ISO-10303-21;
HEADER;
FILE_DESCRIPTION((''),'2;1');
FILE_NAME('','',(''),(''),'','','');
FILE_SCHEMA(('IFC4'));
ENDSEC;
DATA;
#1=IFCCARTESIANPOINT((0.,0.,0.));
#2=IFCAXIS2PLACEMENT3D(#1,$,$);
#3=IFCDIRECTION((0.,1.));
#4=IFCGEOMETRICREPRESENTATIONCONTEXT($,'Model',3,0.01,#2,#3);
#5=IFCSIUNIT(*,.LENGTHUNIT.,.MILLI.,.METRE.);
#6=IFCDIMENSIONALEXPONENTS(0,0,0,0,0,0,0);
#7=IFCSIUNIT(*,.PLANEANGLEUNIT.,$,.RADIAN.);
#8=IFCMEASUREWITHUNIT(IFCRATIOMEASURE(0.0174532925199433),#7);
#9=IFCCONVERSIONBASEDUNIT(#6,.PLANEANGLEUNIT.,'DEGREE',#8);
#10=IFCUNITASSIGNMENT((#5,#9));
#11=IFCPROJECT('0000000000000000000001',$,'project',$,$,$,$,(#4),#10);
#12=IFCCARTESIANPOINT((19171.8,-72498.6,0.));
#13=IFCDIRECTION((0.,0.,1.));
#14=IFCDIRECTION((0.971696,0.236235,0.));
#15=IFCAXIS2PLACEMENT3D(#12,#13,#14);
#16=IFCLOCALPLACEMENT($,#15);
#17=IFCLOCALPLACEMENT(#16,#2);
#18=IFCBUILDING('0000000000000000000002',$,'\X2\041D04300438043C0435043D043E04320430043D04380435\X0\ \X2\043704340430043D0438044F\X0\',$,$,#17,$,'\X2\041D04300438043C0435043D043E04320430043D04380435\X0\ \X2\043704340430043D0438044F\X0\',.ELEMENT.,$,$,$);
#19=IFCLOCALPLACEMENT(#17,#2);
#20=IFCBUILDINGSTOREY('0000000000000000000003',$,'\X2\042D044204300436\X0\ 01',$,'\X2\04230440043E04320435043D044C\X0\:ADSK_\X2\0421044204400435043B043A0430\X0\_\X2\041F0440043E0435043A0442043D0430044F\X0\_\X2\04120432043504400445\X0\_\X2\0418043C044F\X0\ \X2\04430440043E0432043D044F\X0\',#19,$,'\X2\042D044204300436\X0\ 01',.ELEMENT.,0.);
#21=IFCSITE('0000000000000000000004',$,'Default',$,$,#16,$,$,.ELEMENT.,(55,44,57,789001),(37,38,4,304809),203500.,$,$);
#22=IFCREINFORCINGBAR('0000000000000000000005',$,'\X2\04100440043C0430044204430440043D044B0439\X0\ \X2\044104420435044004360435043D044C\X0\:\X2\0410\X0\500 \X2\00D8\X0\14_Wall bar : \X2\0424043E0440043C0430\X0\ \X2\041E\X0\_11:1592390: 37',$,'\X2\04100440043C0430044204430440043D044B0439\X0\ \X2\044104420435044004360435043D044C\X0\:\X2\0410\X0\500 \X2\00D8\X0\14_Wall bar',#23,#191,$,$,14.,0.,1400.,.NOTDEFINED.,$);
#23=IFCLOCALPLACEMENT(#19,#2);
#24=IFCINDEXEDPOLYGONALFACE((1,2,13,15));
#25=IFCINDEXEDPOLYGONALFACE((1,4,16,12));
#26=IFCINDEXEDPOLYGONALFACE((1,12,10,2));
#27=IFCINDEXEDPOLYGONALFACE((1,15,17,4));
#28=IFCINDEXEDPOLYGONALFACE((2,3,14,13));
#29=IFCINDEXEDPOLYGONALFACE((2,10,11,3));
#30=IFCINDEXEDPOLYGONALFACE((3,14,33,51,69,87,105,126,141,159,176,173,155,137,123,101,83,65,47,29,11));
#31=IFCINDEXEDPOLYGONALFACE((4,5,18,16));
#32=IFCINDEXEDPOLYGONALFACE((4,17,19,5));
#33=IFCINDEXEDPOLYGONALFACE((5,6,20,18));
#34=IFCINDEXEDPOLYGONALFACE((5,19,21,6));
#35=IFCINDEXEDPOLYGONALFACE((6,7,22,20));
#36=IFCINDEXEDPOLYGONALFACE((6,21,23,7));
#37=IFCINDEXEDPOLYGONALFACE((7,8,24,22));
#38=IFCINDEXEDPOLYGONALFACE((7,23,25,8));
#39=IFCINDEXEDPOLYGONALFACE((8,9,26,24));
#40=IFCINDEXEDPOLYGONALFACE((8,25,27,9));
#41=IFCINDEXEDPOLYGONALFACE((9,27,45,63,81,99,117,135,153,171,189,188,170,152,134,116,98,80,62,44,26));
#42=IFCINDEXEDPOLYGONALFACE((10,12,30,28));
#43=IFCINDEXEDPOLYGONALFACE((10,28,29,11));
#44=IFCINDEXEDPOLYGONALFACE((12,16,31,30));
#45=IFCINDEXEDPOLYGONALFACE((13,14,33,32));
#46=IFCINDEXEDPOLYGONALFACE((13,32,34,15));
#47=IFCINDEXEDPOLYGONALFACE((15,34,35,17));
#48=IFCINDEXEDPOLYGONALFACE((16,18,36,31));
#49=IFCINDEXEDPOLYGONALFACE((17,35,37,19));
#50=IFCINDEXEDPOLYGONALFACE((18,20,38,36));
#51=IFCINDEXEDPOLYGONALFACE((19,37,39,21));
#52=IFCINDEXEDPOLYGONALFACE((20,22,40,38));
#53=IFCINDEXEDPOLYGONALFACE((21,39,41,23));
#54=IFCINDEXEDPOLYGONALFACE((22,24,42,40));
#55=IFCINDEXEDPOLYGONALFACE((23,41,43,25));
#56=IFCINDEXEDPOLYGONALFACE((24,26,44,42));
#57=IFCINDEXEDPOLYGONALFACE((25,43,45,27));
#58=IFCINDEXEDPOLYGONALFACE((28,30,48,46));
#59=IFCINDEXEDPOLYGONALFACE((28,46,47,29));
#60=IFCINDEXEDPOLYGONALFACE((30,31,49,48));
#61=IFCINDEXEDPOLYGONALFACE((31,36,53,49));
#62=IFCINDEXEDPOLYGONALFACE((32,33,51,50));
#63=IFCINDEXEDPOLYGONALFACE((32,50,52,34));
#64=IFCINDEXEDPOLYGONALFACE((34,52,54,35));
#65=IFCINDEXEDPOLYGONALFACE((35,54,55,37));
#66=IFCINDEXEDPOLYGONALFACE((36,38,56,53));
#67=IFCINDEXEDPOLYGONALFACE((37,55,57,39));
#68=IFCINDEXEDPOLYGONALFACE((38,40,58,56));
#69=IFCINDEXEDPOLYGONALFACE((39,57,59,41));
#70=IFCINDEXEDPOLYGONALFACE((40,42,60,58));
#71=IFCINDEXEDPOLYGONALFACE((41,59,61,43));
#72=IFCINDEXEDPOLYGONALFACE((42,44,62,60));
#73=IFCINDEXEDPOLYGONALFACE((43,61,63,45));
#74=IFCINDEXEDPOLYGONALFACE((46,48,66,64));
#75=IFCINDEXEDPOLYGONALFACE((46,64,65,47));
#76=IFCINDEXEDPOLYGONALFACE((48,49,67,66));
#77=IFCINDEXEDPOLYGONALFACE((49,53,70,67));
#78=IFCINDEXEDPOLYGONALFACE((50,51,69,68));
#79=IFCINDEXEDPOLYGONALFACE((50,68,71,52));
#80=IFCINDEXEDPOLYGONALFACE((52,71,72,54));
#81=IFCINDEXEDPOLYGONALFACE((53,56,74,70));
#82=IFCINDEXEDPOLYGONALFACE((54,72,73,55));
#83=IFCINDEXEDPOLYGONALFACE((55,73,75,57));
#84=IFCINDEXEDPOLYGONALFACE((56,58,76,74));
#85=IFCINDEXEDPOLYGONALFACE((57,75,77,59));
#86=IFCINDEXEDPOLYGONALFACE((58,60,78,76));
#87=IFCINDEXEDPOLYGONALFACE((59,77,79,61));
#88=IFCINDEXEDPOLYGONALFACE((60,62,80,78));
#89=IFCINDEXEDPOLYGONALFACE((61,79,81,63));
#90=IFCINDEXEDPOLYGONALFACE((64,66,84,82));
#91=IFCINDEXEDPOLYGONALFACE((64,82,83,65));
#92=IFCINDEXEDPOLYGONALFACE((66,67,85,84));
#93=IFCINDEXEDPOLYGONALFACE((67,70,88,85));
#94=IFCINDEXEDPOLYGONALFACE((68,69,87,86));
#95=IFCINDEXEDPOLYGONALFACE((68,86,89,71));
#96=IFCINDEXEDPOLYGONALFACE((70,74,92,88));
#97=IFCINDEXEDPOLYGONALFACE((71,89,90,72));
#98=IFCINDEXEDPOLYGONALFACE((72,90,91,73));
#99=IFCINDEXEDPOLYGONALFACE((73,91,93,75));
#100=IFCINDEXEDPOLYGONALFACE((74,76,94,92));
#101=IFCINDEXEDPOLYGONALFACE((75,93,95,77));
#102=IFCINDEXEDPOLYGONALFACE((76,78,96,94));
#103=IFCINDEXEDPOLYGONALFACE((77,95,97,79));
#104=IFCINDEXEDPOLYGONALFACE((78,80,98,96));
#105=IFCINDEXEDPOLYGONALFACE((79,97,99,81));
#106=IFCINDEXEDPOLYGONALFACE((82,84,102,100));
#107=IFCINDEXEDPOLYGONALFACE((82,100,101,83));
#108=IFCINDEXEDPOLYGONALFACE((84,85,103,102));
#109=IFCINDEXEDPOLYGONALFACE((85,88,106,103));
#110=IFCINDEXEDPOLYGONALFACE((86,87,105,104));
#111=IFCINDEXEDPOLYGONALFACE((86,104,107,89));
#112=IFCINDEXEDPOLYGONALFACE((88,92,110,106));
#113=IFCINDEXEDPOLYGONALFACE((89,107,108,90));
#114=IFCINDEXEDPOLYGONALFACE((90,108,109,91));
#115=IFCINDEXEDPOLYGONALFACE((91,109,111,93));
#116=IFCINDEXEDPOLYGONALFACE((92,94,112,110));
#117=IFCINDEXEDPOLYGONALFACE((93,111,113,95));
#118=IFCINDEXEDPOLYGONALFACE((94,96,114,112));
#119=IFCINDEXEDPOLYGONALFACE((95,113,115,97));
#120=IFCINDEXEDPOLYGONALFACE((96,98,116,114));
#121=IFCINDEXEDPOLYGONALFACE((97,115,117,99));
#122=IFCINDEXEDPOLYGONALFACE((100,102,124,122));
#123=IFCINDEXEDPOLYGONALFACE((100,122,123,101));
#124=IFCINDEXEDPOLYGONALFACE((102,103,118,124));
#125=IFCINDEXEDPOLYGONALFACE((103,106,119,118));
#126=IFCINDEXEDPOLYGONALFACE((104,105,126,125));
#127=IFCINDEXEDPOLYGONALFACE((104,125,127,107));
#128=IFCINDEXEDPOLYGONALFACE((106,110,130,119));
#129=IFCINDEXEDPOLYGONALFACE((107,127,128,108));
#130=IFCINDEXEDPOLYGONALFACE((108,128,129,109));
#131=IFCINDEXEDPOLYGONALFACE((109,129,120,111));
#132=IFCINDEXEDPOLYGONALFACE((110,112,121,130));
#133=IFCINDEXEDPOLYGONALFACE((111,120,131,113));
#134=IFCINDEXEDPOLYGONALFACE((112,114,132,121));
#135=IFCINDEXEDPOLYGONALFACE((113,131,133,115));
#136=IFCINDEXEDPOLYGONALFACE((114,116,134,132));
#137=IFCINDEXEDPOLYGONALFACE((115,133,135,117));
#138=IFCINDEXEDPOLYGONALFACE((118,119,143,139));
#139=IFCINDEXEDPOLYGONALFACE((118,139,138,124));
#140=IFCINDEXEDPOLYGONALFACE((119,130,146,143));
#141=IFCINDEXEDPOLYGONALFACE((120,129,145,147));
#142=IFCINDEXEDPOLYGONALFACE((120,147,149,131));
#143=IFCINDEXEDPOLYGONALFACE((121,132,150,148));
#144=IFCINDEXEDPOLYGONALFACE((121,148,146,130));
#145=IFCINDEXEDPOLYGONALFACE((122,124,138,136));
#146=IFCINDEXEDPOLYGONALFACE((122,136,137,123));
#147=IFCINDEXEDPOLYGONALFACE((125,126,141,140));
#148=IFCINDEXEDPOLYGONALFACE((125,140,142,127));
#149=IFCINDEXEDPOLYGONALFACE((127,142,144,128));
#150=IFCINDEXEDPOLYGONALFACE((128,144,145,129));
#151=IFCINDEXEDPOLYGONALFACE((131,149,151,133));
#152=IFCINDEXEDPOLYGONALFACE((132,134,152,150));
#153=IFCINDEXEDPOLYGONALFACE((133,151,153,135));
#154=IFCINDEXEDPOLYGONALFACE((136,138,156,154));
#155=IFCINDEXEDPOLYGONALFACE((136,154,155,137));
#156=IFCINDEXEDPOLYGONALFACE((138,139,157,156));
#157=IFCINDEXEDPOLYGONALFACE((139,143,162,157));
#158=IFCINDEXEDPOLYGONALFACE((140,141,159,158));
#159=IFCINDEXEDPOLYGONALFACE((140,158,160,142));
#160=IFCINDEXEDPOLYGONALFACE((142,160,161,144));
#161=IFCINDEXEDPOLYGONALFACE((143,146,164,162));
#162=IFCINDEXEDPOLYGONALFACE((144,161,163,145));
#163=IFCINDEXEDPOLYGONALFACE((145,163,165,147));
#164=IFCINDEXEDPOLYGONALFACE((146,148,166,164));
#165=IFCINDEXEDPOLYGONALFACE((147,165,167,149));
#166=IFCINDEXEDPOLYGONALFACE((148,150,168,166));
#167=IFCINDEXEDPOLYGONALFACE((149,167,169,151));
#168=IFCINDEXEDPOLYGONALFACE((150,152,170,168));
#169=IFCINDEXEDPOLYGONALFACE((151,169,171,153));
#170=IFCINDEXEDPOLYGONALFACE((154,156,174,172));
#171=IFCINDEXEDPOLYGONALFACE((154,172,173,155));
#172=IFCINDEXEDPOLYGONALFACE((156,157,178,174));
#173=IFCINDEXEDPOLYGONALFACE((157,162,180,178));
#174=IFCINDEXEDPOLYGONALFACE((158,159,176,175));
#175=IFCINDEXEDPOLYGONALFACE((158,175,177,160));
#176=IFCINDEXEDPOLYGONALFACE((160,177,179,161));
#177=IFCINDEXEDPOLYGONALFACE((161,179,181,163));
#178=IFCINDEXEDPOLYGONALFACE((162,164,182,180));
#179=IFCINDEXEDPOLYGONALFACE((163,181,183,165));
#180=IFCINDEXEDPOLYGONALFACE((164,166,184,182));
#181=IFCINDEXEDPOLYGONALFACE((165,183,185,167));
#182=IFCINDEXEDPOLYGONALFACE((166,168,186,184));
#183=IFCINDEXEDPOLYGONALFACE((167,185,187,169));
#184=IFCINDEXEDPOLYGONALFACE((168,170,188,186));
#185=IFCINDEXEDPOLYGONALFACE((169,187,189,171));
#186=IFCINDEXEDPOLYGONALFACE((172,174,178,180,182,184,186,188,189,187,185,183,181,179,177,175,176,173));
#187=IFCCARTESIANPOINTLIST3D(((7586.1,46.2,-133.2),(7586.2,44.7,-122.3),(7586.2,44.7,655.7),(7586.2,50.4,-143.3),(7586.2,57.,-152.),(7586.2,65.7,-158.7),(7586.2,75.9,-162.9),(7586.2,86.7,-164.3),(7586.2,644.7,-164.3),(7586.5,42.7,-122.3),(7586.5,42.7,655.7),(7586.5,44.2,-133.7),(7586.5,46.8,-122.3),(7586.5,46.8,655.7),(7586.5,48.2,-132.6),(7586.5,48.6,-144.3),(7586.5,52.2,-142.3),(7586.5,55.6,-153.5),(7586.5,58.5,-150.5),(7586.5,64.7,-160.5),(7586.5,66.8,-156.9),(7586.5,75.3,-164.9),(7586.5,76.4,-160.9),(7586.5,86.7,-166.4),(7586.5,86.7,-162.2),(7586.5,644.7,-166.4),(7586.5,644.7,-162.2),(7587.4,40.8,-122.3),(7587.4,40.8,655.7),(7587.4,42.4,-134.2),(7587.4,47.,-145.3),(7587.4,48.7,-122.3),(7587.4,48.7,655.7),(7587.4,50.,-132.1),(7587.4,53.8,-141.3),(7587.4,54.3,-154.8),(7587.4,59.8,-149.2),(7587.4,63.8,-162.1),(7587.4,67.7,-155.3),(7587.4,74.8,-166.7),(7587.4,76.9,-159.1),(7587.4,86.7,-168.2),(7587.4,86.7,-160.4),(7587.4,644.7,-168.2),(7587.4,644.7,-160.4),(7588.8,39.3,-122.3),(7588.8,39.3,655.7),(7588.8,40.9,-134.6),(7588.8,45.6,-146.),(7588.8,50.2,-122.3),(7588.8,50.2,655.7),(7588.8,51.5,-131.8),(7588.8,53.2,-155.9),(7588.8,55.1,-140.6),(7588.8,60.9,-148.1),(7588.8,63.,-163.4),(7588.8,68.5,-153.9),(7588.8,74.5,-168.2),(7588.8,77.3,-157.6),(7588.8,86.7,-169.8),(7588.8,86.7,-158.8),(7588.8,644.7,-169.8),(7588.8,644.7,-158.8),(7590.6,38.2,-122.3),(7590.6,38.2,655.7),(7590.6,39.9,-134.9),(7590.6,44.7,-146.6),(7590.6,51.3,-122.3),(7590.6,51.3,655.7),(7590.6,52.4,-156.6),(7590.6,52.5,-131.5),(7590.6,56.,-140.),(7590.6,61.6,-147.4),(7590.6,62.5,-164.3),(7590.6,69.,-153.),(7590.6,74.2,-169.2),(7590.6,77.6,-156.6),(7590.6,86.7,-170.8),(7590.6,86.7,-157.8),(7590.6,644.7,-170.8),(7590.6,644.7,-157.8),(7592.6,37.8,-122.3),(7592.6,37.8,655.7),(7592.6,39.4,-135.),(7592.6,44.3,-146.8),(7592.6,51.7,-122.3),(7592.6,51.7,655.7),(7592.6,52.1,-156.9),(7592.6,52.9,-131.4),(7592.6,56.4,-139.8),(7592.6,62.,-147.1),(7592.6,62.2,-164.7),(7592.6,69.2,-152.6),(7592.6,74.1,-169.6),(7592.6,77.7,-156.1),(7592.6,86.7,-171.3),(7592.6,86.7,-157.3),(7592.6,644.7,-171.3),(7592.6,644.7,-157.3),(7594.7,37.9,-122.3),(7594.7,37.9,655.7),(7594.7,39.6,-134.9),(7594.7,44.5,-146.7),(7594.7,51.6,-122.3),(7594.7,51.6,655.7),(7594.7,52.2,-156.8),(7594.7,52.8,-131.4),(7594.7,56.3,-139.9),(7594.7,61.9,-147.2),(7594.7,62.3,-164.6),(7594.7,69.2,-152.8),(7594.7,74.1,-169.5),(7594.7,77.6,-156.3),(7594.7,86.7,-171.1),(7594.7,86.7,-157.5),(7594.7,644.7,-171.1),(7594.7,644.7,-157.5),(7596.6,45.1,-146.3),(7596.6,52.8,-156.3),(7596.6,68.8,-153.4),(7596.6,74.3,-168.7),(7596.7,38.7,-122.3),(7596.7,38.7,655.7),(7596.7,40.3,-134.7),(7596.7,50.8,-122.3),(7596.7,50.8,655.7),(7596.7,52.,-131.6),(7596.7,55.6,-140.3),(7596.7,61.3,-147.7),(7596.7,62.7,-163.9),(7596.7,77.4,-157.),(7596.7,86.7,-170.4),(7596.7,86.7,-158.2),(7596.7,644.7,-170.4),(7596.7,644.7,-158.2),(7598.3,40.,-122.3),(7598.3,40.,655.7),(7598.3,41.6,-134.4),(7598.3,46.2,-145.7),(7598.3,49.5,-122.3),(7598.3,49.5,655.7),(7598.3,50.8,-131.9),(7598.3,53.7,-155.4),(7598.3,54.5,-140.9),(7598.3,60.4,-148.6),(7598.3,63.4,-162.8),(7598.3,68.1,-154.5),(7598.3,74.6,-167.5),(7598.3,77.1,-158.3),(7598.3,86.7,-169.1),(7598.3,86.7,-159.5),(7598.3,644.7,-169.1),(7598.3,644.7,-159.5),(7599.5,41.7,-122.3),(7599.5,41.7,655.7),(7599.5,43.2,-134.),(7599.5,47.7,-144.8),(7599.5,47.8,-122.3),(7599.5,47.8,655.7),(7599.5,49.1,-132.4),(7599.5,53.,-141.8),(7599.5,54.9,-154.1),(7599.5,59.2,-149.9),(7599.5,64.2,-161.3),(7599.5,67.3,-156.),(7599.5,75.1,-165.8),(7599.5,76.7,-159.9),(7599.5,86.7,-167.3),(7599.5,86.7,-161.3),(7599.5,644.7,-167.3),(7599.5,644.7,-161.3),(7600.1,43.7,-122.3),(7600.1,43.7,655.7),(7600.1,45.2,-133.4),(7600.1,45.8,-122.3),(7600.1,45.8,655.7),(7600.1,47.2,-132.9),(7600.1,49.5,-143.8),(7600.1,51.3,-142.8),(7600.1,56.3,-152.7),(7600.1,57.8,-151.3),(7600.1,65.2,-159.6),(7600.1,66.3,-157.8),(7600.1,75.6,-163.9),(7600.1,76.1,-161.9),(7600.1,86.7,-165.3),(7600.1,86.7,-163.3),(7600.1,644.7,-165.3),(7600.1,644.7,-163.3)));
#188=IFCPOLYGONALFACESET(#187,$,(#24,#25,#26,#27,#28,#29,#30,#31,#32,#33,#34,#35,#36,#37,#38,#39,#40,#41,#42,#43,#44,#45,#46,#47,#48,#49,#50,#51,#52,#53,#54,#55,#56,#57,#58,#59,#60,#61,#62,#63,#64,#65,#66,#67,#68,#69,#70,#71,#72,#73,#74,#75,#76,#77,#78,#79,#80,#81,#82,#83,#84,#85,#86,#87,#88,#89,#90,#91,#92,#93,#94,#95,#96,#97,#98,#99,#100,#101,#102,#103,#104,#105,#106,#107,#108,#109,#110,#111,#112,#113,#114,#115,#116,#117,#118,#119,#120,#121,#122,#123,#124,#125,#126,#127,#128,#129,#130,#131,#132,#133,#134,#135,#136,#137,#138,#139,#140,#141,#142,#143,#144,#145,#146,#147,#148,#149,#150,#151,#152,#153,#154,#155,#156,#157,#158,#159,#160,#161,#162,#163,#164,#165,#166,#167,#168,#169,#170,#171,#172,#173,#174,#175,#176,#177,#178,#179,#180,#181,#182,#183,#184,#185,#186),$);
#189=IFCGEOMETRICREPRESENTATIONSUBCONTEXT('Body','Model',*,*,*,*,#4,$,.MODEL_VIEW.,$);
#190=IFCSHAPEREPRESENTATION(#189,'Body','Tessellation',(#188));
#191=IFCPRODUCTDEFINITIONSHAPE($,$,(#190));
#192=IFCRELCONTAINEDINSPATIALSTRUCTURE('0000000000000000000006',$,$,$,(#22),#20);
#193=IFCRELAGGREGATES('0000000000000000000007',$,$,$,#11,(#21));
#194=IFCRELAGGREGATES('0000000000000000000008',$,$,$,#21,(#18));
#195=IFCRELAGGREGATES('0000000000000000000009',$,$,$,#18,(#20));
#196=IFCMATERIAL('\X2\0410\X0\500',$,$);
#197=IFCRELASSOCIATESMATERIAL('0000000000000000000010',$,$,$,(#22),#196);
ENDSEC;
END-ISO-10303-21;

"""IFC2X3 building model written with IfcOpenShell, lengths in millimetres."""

from ifc_helpers import new_model, entity, si_unit, converted_unit, direction, frame, origin, place, context, subcontext, project, spatial, material, element, save


model = new_model("IFC2X3")

# Units and contexts
model_context = context("Model", 3, precision=0.01, world=origin(), true_north=direction((0.0, 1.0)))
body_context = subcontext(model_context, "Body", "Model", "MODEL_VIEW")
ifc_project = project(units=[si_unit("LENGTHUNIT", "METRE", prefix="MILLI"), converted_unit("PLANEANGLEUNIT", "DEGREE", entity("IfcRatioMeasure", 0.0174532925199433), si_unit("PLANEANGLEUNIT", "RADIAN"), dimensions=[0, 0, 0, 0, 0, 0, 0])], contexts=[model_context])

# Site, building, storey
site_placement = place(None, frame((19171.8, -72498.6, 0.0), z_axis=(0.0, 0.0, 1.0), x_axis=(0.971696, 0.236235, 0.0)))
site = spatial("IfcSite", under=ifc_project, at=site_placement, Name="Default", CompositionType="ELEMENT", RefLatitude=(55, 44, 57, 789001), RefLongitude=(37, 38, 4, 304809), RefElevation=203500.0)
building_placement = place(site_placement, origin())
building = spatial("IfcBuilding", under=site, at=building_placement, Name="Наименование здания", LongName="Наименование здания", CompositionType="ELEMENT")
storey_placement = place(building_placement, origin())
storey = spatial("IfcBuildingStorey", under=building, at=storey_placement, Name="Этаж 01", ObjectType="Уровень:ADSK_Стрелка_Проектная_Вверх_Имя уровня", LongName="Этаж 01", CompositionType="ELEMENT", Elevation=0.0)

# Reinforcing bar
ifc_material = material(Name="А500")
placement = place(storey_placement, origin())
element("IfcReinforcingBar", 1, at=placement, inside=storey, material=ifc_material, Name="Арматурный стержень:А500 Ø14_Wall bar : Форма О_11:1592390: 37", ObjectType="Арматурный стержень:А500 Ø14_Wall bar", BarLength=1400.0, BarRole="NOTDEFINED", CrossSectionArea=0.0, NominalDiameter=14.0, context=body_context, shape_type="AdvancedSweptSolid", body=[
    entity("IfcSweptDiskSolid", entity("IfcCompositeCurve", [entity("IfcCompositeCurveSegment", "CONTINUOUS", True, entity("IfcPolyline", [entity("IfcCartesianPoint", [7593.1, 44.7, 655.7]), entity("IfcCartesianPoint", [7593.1, 44.7, -122.3])])), entity("IfcCompositeCurveSegment", "CONTINUOUS", True, entity("IfcTrimmedCurve", entity("IfcCircle", entity("IfcAxis2Placement3D", entity("IfcCartesianPoint", [7593.1, 86.7, -122.3]), entity("IfcDirection", [1.0, 0.0, 0.0]), entity("IfcDirection", [0.0, 0.0, -1.0])), 42.0), [entity("IfcParameterValue", 270.0)], [entity("IfcParameterValue", 360.0)], True, "PARAMETER")), entity("IfcCompositeCurveSegment", "CONTINUOUS", True, entity("IfcPolyline", [entity("IfcCartesianPoint", [7593.1, 86.7, -164.3]), entity("IfcCartesianPoint", [7593.1, 644.7, -164.3])]))], False), 7.0, None, 0.0, 92.0),
])

save(model, "model.ifc")
